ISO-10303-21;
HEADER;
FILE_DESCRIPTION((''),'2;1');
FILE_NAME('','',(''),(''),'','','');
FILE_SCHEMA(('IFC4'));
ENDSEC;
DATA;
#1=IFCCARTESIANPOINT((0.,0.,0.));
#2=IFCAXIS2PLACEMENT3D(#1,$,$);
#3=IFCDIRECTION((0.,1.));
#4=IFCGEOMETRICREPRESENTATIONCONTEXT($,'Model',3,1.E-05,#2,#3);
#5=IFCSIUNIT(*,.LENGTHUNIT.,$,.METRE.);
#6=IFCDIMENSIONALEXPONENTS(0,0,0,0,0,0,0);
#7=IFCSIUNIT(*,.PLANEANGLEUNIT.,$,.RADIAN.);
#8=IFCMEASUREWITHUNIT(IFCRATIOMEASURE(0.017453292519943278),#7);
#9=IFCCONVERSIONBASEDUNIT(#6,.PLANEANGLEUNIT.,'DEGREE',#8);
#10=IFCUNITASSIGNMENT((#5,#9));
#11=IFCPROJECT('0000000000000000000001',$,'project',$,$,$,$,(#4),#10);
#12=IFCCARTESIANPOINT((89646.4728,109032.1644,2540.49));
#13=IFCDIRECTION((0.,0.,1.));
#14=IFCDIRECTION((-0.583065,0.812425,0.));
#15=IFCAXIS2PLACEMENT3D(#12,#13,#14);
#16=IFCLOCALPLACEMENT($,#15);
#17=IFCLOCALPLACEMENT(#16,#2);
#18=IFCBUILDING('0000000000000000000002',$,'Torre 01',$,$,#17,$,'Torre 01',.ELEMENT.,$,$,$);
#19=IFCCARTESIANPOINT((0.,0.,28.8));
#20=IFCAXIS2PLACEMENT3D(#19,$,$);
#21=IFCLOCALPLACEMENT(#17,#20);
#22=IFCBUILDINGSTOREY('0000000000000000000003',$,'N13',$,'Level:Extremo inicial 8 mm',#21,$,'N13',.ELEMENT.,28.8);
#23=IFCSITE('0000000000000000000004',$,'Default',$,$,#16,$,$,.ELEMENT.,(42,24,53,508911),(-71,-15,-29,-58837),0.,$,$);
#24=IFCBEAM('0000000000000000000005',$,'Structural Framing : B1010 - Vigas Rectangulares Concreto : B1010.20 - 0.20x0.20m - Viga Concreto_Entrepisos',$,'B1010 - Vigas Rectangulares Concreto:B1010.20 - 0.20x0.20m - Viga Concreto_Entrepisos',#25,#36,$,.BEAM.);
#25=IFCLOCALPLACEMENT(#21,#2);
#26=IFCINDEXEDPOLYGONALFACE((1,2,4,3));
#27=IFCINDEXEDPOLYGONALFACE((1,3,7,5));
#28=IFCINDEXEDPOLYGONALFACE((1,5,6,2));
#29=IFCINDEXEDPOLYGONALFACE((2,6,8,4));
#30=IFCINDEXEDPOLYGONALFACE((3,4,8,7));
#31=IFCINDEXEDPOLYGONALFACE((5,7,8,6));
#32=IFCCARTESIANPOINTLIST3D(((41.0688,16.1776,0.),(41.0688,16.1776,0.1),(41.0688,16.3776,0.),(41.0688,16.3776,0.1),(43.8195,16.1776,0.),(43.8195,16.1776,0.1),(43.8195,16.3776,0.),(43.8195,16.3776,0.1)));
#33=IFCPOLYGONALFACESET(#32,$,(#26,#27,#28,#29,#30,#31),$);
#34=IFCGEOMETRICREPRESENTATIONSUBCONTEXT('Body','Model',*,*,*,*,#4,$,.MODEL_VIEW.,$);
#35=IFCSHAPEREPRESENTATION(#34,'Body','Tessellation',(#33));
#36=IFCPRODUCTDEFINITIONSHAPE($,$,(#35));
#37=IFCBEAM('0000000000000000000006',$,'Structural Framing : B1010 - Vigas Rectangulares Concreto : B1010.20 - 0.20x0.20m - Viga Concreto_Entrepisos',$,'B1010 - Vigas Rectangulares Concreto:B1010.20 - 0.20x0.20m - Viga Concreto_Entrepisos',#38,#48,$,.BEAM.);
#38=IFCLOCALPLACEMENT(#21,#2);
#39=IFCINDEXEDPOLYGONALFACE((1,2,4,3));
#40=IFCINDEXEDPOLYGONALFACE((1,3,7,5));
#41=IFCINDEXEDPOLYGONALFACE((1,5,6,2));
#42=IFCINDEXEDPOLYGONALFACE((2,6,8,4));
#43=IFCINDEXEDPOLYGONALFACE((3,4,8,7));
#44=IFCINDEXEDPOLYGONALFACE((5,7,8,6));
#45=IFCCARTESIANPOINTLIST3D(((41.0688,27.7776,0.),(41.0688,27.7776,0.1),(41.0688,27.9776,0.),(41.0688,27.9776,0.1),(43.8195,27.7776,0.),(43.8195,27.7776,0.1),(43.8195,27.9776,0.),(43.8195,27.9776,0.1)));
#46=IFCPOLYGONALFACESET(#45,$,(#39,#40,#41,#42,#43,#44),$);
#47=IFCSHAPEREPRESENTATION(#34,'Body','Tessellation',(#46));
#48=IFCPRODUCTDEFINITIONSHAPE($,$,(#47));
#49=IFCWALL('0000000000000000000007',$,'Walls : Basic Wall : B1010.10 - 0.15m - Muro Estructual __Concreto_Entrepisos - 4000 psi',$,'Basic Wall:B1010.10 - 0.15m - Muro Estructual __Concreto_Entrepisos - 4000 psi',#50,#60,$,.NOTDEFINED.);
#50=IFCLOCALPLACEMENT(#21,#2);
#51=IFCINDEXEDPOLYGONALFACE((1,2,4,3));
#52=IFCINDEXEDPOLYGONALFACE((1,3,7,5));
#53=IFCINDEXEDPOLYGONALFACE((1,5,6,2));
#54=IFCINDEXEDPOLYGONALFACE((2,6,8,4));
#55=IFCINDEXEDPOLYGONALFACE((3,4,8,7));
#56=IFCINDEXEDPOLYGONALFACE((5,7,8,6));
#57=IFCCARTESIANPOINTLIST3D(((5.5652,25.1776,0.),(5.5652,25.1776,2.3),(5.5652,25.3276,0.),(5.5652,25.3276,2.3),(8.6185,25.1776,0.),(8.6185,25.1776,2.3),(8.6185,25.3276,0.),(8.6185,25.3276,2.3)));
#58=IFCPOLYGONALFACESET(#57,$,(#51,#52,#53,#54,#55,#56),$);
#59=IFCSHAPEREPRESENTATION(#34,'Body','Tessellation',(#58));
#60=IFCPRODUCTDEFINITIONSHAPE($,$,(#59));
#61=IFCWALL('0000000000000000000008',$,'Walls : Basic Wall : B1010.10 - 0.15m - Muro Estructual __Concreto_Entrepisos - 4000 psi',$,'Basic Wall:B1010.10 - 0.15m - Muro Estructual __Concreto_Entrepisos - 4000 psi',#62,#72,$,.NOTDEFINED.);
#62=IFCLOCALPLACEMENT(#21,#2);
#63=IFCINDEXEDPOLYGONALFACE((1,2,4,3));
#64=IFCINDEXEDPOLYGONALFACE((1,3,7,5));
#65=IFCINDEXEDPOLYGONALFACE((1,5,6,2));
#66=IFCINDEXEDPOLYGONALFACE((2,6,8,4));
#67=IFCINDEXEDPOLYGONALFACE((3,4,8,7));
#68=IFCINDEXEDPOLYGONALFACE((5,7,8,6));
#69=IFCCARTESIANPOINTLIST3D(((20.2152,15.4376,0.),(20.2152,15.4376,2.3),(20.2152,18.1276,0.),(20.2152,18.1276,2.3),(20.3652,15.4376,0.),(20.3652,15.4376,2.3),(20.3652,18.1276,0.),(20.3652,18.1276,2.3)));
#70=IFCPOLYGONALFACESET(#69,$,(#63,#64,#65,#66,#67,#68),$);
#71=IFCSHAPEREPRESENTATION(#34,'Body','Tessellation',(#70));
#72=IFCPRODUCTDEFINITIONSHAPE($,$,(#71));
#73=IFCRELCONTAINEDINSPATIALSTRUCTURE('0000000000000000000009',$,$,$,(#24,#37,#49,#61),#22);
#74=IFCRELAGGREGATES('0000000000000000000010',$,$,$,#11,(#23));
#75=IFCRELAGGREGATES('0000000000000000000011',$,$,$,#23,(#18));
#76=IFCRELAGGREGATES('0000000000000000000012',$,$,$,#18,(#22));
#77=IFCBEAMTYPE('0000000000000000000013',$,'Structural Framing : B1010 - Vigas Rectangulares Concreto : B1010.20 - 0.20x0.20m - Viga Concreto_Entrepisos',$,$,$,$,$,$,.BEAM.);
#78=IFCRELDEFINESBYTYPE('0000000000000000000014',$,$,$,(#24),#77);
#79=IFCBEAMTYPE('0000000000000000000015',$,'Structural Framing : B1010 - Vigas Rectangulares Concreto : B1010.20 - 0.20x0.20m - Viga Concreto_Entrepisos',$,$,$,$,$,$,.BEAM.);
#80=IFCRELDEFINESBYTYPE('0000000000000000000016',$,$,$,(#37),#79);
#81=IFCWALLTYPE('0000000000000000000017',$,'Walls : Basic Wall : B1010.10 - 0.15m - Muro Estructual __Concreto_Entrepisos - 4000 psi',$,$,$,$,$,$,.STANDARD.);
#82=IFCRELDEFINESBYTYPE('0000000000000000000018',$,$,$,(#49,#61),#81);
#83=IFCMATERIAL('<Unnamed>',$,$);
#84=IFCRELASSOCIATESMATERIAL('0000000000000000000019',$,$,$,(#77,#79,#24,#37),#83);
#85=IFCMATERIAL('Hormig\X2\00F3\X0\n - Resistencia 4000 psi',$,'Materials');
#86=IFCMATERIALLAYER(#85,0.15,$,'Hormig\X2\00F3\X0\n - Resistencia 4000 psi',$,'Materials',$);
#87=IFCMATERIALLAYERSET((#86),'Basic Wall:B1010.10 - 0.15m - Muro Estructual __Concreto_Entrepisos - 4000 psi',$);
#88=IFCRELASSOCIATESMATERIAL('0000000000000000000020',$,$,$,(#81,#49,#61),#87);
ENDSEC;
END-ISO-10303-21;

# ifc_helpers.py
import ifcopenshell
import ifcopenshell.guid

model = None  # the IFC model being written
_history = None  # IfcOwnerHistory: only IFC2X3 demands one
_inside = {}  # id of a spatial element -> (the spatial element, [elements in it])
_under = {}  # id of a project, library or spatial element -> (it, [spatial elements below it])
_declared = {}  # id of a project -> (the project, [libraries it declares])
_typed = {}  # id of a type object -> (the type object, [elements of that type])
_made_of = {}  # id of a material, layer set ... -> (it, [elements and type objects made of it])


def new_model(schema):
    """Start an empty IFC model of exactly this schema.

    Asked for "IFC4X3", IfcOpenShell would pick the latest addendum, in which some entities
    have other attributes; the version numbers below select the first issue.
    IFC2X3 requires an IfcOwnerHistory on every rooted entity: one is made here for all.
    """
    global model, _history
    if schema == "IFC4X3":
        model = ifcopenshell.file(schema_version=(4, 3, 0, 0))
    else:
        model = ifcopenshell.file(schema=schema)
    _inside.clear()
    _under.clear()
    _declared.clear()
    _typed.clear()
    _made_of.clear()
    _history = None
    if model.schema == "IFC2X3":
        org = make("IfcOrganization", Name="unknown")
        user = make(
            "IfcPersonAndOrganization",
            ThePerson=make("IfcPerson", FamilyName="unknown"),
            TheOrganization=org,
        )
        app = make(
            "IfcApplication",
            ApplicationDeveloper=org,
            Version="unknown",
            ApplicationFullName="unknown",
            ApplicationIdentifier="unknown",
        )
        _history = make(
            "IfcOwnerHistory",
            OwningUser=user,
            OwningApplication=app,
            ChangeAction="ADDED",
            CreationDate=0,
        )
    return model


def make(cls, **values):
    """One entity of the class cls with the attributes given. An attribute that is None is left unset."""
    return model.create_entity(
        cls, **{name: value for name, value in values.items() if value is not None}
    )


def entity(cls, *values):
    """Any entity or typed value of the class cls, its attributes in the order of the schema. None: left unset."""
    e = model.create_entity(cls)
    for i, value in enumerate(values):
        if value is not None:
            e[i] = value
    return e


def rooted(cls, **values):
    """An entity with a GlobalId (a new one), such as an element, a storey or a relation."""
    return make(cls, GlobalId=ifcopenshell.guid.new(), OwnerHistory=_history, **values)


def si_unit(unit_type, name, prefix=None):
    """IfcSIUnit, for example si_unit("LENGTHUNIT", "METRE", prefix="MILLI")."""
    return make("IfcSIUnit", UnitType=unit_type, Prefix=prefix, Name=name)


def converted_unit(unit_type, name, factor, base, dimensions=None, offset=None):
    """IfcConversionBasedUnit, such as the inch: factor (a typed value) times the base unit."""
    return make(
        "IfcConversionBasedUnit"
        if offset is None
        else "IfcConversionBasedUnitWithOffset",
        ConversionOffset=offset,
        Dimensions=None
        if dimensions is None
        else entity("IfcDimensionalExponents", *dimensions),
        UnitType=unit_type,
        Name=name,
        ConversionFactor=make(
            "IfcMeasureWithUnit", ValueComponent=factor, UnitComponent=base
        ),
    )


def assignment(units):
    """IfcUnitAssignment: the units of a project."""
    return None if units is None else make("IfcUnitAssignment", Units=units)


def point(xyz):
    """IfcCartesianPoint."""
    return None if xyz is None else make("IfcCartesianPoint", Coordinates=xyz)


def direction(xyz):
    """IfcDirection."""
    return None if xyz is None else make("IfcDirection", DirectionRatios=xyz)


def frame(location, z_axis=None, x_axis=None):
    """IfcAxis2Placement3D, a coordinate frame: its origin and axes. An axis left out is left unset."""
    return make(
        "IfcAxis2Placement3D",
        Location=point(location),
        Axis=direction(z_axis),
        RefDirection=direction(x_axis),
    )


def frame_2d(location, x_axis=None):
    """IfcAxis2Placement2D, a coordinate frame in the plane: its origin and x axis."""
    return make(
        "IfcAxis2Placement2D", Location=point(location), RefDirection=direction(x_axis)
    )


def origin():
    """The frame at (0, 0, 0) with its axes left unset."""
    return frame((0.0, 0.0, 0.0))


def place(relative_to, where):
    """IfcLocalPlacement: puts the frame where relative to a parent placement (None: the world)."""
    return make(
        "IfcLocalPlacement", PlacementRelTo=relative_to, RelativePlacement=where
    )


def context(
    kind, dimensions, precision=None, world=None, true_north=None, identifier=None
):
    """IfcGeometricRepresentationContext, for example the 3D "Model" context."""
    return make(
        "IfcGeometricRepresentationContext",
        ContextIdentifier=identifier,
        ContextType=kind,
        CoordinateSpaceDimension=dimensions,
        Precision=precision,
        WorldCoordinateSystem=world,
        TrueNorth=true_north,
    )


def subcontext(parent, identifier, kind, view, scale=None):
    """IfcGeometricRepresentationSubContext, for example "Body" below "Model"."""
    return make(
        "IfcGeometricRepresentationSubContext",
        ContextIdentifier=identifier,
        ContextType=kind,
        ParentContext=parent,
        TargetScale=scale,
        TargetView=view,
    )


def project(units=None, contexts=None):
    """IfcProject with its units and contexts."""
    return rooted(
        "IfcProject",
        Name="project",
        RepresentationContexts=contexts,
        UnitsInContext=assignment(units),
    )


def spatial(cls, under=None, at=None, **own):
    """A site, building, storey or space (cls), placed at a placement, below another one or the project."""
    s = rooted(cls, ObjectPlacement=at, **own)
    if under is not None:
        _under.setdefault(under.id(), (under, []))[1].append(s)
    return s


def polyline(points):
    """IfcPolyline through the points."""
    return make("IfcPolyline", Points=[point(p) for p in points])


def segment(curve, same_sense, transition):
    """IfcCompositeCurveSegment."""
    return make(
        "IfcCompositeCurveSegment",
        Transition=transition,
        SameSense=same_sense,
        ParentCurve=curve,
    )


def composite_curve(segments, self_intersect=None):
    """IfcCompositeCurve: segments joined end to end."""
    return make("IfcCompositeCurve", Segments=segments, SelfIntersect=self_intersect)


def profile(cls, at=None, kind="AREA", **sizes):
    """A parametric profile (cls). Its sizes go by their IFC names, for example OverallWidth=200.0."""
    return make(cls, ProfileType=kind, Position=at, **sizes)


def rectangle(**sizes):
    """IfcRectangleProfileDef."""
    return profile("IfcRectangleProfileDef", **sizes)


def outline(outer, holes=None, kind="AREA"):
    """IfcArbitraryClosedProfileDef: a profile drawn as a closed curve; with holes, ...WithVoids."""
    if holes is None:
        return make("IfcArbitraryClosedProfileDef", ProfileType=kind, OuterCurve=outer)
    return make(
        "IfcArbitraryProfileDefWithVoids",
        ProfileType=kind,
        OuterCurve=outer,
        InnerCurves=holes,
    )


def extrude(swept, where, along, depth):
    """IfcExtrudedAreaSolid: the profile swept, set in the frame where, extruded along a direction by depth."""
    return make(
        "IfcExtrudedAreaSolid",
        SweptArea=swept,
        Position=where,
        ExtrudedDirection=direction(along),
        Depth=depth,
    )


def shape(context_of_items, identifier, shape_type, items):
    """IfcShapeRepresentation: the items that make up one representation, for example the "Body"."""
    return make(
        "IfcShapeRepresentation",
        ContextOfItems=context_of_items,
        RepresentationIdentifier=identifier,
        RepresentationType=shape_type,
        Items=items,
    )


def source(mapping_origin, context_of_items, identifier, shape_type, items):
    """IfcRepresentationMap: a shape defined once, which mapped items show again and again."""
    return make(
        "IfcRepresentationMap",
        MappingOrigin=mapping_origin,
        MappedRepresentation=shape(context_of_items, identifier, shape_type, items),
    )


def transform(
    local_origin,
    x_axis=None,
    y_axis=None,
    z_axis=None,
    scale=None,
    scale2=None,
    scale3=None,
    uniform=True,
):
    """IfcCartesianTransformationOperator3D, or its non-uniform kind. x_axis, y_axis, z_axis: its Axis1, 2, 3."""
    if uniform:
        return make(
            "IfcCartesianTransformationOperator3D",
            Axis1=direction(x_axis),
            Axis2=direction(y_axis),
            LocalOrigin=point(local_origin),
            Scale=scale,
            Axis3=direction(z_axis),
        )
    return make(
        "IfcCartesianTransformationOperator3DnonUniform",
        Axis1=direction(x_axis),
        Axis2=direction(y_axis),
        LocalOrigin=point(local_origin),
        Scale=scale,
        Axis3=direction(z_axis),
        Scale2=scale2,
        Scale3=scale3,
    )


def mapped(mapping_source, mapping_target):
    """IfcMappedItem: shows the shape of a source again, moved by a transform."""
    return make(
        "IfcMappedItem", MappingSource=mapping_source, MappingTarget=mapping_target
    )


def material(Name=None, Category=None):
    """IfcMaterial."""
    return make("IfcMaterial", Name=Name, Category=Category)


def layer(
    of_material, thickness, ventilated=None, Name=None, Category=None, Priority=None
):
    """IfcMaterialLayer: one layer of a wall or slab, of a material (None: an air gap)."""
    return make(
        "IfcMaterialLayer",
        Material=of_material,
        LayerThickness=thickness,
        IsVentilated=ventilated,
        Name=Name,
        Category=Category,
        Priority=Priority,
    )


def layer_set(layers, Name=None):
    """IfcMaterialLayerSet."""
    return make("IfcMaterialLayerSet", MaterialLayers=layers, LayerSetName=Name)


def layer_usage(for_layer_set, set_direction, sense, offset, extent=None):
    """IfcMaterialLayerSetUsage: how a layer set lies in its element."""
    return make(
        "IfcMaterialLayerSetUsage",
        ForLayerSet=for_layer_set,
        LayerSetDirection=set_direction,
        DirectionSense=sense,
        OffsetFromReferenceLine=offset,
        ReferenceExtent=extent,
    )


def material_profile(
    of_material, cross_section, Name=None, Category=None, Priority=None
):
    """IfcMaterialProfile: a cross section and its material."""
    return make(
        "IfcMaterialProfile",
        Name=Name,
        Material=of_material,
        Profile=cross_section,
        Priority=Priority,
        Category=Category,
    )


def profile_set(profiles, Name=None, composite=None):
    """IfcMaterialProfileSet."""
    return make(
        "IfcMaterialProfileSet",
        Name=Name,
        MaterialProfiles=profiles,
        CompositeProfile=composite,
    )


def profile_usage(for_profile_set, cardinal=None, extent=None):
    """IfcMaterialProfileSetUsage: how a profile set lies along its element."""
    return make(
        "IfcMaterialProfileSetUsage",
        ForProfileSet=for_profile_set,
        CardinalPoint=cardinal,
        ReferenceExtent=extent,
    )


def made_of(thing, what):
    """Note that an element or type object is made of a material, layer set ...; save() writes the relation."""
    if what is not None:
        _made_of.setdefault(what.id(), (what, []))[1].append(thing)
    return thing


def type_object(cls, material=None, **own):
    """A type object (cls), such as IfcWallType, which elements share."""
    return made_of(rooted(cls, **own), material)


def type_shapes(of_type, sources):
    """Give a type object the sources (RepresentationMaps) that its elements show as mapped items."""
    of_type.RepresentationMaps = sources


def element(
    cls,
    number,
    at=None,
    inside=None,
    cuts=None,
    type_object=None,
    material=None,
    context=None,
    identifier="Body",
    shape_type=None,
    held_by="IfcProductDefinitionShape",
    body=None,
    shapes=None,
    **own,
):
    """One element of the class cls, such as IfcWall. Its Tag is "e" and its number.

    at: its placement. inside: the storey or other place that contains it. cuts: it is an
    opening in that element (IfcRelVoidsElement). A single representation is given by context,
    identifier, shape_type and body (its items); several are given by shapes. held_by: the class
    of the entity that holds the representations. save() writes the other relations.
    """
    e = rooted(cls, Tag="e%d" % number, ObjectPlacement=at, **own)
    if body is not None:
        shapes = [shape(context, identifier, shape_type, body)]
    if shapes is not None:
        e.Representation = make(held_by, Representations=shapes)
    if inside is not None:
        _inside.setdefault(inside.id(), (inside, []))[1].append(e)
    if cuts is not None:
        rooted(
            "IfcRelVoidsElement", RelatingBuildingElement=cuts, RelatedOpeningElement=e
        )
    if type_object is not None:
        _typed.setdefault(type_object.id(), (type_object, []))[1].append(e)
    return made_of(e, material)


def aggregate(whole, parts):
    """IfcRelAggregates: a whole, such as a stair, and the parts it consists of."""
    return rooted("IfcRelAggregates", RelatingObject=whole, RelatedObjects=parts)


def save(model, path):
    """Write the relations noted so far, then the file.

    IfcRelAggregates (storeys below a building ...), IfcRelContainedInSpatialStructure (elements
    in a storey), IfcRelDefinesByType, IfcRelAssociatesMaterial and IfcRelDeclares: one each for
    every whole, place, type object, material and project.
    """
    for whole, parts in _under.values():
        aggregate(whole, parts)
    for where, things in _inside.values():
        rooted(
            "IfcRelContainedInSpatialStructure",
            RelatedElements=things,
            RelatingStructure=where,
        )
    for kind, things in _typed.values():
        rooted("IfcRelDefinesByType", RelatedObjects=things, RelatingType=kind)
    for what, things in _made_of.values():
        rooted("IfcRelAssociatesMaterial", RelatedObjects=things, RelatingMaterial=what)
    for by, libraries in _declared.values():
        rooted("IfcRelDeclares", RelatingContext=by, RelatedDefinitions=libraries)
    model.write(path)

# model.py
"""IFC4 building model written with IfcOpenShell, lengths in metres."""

from ifc_helpers import new_model, entity, si_unit, converted_unit, direction, frame, frame_2d, origin, place, context, subcontext, project, spatial, polyline, segment, composite_curve, rectangle, outline, extrude, source, transform, mapped, material, layer, layer_set, layer_usage, material_profile, profile_set, profile_usage, type_object, type_shapes, element, save


model = new_model("IFC4")

# Units and contexts
model_context = context("Model", 3, precision=1e-05, world=origin(), true_north=direction((0.0, 1.0)))
body_context = subcontext(model_context, "Body", "Model", "MODEL_VIEW")
ifc_project = project(units=[si_unit("LENGTHUNIT", "METRE"), converted_unit("PLANEANGLEUNIT", "DEGREE", entity("IfcRatioMeasure", 0.017453292519943278), si_unit("PLANEANGLEUNIT", "RADIAN"), dimensions=[0, 0, 0, 0, 0, 0, 0])], contexts=[model_context])

# Site, building, storey
site_placement = place(None, frame((89646.4728, 109032.1644, 2540.49), z_axis=(0.0, 0.0, 1.0), x_axis=(-0.583065, 0.812425, 0.0)))
site = spatial("IfcSite", under=ifc_project, at=site_placement, Name="Default", CompositionType="ELEMENT", RefLatitude=(42, 24, 53, 508911), RefLongitude=(-71, -15, -29, -58837), RefElevation=0.0)
building_placement = place(site_placement, origin())
building = spatial("IfcBuilding", under=site, at=building_placement, Name="Torre 01", LongName="Torre 01", CompositionType="ELEMENT")
storey_placement = place(building_placement, frame((0.0, 0.0, 28.8)))
storey = spatial("IfcBuildingStorey", under=building, at=storey_placement, Name="N13", ObjectType="Level:Extremo inicial 8 mm", LongName="N13", CompositionType="ELEMENT", Elevation=28.8)

# Beams
ifc_material_1 = material(Name="<Unnamed>")
ifc_material_profile_1 = material_profile(ifc_material_1, outline(composite_curve([segment(polyline([(-0.1, 0.0, 0.0), (-0.1, 0.1, 0.0)]), True, "CONTINUOUS"), segment(polyline([(-0.1, 0.1, 0.0), (0.1, 0.1, 0.0)]), True, "CONTINUOUS"), segment(polyline([(0.1, 0.1, 0.0), (0.1, 0.0, 0.0)]), True, "CONTINUOUS"), segment(polyline([(0.1, 0.0, 0.0), (-0.1, 0.0, 0.0)]), True, "CONTINUOUS")], self_intersect=False), kind="CURVE"), Name="B1010.20 - 0.20x0.20m - Viga Concreto_Entrepisos")
ifc_material_profile_2 = material_profile(ifc_material_1, outline(composite_curve([segment(polyline([(-1.3, -0.1, 0.1), (-1.3, 0.1, 0.1)]), True, "CONTINUOUS"), segment(polyline([(-1.3, 0.1, 0.1), (-1.3, 0.1, -0.1)]), True, "CONTINUOUS"), segment(polyline([(-1.3, 0.1, -0.1), (-1.3, -0.1, -0.1)]), True, "CONTINUOUS"), segment(polyline([(-1.3, -0.1, -0.1), (-1.3, -0.1, 0.1)]), True, "CONTINUOUS")], self_intersect=False), kind="CURVE"), Name="B1010.20 - 0.20x0.20m - Viga Concreto_Entrepisos")
ifc_profile_set_1 = profile_set([ifc_material_profile_1, ifc_material_profile_2], Name="B1010.20 - 0.20x0.20m - Viga Concreto_Entrepisos")
ifc_profile_usage_1 = profile_usage(ifc_profile_set_1, cardinal=8)
beam_type_1 = type_object("IfcBeamType", Name="Structural Framing : B1010 - Vigas Rectangulares Concreto : B1010.20 - 0.20x0.20m - Viga Concreto_Entrepisos", PredefinedType="BEAM", material=ifc_profile_set_1)
shared_shape_1 = source(origin(), body_context, "Body", "SweptSolid", [
    extrude(rectangle(XDim=0.1, YDim=0.2, at=frame_2d((0.0, 0.0), x_axis=(1.0, 0.0))), frame((43.8195, 16.2776, 28.85), z_axis=(-1.0, 0.0, 0.0), x_axis=(0.0, 0.0, -1.0)), (0.0, 0.0, 1.0), 2.7507),
])
type_shapes(beam_type_1, [shared_shape_1])
beam_1_placement = place(storey_placement, frame((0.0, 0.0, -28.8)))
element("IfcBeam", 1, at=beam_1_placement, inside=storey, type_object=beam_type_1, material=ifc_profile_usage_1, Name="Structural Framing : B1010 - Vigas Rectangulares Concreto : B1010.20 - 0.20x0.20m - Viga Concreto_Entrepisos", ObjectType="B1010 - Vigas Rectangulares Concreto:B1010.20 - 0.20x0.20m - Viga Concreto_Entrepisos", PredefinedType="BEAM", context=body_context, shape_type="MappedRepresentation", body=[
    mapped(shared_shape_1, transform((0.0, 0.0, 0.0), scale=1.0)),
])
ifc_profile_usage_2 = profile_usage(ifc_profile_set_1, cardinal=8)
beam_type_2 = type_object("IfcBeamType", Name="Structural Framing : B1010 - Vigas Rectangulares Concreto : B1010.20 - 0.20x0.20m - Viga Concreto_Entrepisos", PredefinedType="BEAM", material=ifc_profile_set_1)
shared_shape_2 = source(origin(), body_context, "Body", "SweptSolid", [
    extrude(rectangle(XDim=0.1, YDim=0.2, at=frame_2d((0.0, 0.0), x_axis=(1.0, 0.0))), frame((43.8195, 27.8776, 28.85), z_axis=(-1.0, 0.0, 0.0), x_axis=(0.0, 0.0, -1.0)), (0.0, 0.0, 1.0), 2.7507),
])
type_shapes(beam_type_2, [shared_shape_2])
beam_2_placement = place(storey_placement, frame((0.0, 0.0, -28.8)))
element("IfcBeam", 2, at=beam_2_placement, inside=storey, type_object=beam_type_2, material=ifc_profile_usage_2, Name="Structural Framing : B1010 - Vigas Rectangulares Concreto : B1010.20 - 0.20x0.20m - Viga Concreto_Entrepisos", ObjectType="B1010 - Vigas Rectangulares Concreto:B1010.20 - 0.20x0.20m - Viga Concreto_Entrepisos", PredefinedType="BEAM", context=body_context, shape_type="MappedRepresentation", body=[
    mapped(shared_shape_2, transform((0.0, 0.0, 0.0), scale=1.0)),
])

# Walls
ifc_material_2 = material(Name="Hormigón - Resistencia 4000 psi", Category="Materials")
ifc_layer_1 = layer(ifc_material_2, 0.15, Name="Hormigón - Resistencia 4000 psi", Category="Materials")
ifc_layer_set_1 = layer_set([ifc_layer_1], Name="Basic Wall:B1010.10 - 0.15m - Muro Estructual __Concreto_Entrepisos - 4000 psi")
ifc_layer_usage_1 = layer_usage(ifc_layer_set_1, "AXIS2", "NEGATIVE", 0.075)
wall_type = type_object("IfcWallType", Name="Walls : Basic Wall : B1010.10 - 0.15m - Muro Estructual __Concreto_Entrepisos - 4000 psi", PredefinedType="STANDARD", material=ifc_layer_set_1)
wall_1_placement = place(storey_placement, frame((5.5652, 25.2526, 0.0)))
element("IfcWall", 3, at=wall_1_placement, inside=storey, type_object=wall_type, material=ifc_layer_usage_1, Name="Walls : Basic Wall : B1010.10 - 0.15m - Muro Estructual __Concreto_Entrepisos - 4000 psi", ObjectType="Basic Wall:B1010.10 - 0.15m - Muro Estructual __Concreto_Entrepisos - 4000 psi", PredefinedType="NOTDEFINED", context=body_context, shape_type="SweptSolid", body=[
    extrude(rectangle(XDim=3.0533, YDim=0.15, at=frame_2d((1.5267, 0.0), x_axis=(-1.0, 0.0))), origin(), (0.0, 0.0, 1.0), 2.3),
])
ifc_layer_usage_2 = layer_usage(ifc_layer_set_1, "AXIS2", "NEGATIVE", 0.075)
wall_2_placement = place(storey_placement, frame((20.2902, 15.4376, 0.0), z_axis=(0.0, 0.0, 1.0), x_axis=(0.0, 1.0, 0.0)))
element("IfcWall", 4, at=wall_2_placement, inside=storey, type_object=wall_type, material=ifc_layer_usage_2, Name="Walls : Basic Wall : B1010.10 - 0.15m - Muro Estructual __Concreto_Entrepisos - 4000 psi", ObjectType="Basic Wall:B1010.10 - 0.15m - Muro Estructual __Concreto_Entrepisos - 4000 psi", PredefinedType="NOTDEFINED", context=body_context, shape_type="SweptSolid", body=[
    extrude(rectangle(XDim=2.69, YDim=0.15, at=frame_2d((1.345, 0.0), x_axis=(-1.0, 0.0))), origin(), (0.0, 0.0, 1.0), 2.3),
])

save(model, "model.ifc")
